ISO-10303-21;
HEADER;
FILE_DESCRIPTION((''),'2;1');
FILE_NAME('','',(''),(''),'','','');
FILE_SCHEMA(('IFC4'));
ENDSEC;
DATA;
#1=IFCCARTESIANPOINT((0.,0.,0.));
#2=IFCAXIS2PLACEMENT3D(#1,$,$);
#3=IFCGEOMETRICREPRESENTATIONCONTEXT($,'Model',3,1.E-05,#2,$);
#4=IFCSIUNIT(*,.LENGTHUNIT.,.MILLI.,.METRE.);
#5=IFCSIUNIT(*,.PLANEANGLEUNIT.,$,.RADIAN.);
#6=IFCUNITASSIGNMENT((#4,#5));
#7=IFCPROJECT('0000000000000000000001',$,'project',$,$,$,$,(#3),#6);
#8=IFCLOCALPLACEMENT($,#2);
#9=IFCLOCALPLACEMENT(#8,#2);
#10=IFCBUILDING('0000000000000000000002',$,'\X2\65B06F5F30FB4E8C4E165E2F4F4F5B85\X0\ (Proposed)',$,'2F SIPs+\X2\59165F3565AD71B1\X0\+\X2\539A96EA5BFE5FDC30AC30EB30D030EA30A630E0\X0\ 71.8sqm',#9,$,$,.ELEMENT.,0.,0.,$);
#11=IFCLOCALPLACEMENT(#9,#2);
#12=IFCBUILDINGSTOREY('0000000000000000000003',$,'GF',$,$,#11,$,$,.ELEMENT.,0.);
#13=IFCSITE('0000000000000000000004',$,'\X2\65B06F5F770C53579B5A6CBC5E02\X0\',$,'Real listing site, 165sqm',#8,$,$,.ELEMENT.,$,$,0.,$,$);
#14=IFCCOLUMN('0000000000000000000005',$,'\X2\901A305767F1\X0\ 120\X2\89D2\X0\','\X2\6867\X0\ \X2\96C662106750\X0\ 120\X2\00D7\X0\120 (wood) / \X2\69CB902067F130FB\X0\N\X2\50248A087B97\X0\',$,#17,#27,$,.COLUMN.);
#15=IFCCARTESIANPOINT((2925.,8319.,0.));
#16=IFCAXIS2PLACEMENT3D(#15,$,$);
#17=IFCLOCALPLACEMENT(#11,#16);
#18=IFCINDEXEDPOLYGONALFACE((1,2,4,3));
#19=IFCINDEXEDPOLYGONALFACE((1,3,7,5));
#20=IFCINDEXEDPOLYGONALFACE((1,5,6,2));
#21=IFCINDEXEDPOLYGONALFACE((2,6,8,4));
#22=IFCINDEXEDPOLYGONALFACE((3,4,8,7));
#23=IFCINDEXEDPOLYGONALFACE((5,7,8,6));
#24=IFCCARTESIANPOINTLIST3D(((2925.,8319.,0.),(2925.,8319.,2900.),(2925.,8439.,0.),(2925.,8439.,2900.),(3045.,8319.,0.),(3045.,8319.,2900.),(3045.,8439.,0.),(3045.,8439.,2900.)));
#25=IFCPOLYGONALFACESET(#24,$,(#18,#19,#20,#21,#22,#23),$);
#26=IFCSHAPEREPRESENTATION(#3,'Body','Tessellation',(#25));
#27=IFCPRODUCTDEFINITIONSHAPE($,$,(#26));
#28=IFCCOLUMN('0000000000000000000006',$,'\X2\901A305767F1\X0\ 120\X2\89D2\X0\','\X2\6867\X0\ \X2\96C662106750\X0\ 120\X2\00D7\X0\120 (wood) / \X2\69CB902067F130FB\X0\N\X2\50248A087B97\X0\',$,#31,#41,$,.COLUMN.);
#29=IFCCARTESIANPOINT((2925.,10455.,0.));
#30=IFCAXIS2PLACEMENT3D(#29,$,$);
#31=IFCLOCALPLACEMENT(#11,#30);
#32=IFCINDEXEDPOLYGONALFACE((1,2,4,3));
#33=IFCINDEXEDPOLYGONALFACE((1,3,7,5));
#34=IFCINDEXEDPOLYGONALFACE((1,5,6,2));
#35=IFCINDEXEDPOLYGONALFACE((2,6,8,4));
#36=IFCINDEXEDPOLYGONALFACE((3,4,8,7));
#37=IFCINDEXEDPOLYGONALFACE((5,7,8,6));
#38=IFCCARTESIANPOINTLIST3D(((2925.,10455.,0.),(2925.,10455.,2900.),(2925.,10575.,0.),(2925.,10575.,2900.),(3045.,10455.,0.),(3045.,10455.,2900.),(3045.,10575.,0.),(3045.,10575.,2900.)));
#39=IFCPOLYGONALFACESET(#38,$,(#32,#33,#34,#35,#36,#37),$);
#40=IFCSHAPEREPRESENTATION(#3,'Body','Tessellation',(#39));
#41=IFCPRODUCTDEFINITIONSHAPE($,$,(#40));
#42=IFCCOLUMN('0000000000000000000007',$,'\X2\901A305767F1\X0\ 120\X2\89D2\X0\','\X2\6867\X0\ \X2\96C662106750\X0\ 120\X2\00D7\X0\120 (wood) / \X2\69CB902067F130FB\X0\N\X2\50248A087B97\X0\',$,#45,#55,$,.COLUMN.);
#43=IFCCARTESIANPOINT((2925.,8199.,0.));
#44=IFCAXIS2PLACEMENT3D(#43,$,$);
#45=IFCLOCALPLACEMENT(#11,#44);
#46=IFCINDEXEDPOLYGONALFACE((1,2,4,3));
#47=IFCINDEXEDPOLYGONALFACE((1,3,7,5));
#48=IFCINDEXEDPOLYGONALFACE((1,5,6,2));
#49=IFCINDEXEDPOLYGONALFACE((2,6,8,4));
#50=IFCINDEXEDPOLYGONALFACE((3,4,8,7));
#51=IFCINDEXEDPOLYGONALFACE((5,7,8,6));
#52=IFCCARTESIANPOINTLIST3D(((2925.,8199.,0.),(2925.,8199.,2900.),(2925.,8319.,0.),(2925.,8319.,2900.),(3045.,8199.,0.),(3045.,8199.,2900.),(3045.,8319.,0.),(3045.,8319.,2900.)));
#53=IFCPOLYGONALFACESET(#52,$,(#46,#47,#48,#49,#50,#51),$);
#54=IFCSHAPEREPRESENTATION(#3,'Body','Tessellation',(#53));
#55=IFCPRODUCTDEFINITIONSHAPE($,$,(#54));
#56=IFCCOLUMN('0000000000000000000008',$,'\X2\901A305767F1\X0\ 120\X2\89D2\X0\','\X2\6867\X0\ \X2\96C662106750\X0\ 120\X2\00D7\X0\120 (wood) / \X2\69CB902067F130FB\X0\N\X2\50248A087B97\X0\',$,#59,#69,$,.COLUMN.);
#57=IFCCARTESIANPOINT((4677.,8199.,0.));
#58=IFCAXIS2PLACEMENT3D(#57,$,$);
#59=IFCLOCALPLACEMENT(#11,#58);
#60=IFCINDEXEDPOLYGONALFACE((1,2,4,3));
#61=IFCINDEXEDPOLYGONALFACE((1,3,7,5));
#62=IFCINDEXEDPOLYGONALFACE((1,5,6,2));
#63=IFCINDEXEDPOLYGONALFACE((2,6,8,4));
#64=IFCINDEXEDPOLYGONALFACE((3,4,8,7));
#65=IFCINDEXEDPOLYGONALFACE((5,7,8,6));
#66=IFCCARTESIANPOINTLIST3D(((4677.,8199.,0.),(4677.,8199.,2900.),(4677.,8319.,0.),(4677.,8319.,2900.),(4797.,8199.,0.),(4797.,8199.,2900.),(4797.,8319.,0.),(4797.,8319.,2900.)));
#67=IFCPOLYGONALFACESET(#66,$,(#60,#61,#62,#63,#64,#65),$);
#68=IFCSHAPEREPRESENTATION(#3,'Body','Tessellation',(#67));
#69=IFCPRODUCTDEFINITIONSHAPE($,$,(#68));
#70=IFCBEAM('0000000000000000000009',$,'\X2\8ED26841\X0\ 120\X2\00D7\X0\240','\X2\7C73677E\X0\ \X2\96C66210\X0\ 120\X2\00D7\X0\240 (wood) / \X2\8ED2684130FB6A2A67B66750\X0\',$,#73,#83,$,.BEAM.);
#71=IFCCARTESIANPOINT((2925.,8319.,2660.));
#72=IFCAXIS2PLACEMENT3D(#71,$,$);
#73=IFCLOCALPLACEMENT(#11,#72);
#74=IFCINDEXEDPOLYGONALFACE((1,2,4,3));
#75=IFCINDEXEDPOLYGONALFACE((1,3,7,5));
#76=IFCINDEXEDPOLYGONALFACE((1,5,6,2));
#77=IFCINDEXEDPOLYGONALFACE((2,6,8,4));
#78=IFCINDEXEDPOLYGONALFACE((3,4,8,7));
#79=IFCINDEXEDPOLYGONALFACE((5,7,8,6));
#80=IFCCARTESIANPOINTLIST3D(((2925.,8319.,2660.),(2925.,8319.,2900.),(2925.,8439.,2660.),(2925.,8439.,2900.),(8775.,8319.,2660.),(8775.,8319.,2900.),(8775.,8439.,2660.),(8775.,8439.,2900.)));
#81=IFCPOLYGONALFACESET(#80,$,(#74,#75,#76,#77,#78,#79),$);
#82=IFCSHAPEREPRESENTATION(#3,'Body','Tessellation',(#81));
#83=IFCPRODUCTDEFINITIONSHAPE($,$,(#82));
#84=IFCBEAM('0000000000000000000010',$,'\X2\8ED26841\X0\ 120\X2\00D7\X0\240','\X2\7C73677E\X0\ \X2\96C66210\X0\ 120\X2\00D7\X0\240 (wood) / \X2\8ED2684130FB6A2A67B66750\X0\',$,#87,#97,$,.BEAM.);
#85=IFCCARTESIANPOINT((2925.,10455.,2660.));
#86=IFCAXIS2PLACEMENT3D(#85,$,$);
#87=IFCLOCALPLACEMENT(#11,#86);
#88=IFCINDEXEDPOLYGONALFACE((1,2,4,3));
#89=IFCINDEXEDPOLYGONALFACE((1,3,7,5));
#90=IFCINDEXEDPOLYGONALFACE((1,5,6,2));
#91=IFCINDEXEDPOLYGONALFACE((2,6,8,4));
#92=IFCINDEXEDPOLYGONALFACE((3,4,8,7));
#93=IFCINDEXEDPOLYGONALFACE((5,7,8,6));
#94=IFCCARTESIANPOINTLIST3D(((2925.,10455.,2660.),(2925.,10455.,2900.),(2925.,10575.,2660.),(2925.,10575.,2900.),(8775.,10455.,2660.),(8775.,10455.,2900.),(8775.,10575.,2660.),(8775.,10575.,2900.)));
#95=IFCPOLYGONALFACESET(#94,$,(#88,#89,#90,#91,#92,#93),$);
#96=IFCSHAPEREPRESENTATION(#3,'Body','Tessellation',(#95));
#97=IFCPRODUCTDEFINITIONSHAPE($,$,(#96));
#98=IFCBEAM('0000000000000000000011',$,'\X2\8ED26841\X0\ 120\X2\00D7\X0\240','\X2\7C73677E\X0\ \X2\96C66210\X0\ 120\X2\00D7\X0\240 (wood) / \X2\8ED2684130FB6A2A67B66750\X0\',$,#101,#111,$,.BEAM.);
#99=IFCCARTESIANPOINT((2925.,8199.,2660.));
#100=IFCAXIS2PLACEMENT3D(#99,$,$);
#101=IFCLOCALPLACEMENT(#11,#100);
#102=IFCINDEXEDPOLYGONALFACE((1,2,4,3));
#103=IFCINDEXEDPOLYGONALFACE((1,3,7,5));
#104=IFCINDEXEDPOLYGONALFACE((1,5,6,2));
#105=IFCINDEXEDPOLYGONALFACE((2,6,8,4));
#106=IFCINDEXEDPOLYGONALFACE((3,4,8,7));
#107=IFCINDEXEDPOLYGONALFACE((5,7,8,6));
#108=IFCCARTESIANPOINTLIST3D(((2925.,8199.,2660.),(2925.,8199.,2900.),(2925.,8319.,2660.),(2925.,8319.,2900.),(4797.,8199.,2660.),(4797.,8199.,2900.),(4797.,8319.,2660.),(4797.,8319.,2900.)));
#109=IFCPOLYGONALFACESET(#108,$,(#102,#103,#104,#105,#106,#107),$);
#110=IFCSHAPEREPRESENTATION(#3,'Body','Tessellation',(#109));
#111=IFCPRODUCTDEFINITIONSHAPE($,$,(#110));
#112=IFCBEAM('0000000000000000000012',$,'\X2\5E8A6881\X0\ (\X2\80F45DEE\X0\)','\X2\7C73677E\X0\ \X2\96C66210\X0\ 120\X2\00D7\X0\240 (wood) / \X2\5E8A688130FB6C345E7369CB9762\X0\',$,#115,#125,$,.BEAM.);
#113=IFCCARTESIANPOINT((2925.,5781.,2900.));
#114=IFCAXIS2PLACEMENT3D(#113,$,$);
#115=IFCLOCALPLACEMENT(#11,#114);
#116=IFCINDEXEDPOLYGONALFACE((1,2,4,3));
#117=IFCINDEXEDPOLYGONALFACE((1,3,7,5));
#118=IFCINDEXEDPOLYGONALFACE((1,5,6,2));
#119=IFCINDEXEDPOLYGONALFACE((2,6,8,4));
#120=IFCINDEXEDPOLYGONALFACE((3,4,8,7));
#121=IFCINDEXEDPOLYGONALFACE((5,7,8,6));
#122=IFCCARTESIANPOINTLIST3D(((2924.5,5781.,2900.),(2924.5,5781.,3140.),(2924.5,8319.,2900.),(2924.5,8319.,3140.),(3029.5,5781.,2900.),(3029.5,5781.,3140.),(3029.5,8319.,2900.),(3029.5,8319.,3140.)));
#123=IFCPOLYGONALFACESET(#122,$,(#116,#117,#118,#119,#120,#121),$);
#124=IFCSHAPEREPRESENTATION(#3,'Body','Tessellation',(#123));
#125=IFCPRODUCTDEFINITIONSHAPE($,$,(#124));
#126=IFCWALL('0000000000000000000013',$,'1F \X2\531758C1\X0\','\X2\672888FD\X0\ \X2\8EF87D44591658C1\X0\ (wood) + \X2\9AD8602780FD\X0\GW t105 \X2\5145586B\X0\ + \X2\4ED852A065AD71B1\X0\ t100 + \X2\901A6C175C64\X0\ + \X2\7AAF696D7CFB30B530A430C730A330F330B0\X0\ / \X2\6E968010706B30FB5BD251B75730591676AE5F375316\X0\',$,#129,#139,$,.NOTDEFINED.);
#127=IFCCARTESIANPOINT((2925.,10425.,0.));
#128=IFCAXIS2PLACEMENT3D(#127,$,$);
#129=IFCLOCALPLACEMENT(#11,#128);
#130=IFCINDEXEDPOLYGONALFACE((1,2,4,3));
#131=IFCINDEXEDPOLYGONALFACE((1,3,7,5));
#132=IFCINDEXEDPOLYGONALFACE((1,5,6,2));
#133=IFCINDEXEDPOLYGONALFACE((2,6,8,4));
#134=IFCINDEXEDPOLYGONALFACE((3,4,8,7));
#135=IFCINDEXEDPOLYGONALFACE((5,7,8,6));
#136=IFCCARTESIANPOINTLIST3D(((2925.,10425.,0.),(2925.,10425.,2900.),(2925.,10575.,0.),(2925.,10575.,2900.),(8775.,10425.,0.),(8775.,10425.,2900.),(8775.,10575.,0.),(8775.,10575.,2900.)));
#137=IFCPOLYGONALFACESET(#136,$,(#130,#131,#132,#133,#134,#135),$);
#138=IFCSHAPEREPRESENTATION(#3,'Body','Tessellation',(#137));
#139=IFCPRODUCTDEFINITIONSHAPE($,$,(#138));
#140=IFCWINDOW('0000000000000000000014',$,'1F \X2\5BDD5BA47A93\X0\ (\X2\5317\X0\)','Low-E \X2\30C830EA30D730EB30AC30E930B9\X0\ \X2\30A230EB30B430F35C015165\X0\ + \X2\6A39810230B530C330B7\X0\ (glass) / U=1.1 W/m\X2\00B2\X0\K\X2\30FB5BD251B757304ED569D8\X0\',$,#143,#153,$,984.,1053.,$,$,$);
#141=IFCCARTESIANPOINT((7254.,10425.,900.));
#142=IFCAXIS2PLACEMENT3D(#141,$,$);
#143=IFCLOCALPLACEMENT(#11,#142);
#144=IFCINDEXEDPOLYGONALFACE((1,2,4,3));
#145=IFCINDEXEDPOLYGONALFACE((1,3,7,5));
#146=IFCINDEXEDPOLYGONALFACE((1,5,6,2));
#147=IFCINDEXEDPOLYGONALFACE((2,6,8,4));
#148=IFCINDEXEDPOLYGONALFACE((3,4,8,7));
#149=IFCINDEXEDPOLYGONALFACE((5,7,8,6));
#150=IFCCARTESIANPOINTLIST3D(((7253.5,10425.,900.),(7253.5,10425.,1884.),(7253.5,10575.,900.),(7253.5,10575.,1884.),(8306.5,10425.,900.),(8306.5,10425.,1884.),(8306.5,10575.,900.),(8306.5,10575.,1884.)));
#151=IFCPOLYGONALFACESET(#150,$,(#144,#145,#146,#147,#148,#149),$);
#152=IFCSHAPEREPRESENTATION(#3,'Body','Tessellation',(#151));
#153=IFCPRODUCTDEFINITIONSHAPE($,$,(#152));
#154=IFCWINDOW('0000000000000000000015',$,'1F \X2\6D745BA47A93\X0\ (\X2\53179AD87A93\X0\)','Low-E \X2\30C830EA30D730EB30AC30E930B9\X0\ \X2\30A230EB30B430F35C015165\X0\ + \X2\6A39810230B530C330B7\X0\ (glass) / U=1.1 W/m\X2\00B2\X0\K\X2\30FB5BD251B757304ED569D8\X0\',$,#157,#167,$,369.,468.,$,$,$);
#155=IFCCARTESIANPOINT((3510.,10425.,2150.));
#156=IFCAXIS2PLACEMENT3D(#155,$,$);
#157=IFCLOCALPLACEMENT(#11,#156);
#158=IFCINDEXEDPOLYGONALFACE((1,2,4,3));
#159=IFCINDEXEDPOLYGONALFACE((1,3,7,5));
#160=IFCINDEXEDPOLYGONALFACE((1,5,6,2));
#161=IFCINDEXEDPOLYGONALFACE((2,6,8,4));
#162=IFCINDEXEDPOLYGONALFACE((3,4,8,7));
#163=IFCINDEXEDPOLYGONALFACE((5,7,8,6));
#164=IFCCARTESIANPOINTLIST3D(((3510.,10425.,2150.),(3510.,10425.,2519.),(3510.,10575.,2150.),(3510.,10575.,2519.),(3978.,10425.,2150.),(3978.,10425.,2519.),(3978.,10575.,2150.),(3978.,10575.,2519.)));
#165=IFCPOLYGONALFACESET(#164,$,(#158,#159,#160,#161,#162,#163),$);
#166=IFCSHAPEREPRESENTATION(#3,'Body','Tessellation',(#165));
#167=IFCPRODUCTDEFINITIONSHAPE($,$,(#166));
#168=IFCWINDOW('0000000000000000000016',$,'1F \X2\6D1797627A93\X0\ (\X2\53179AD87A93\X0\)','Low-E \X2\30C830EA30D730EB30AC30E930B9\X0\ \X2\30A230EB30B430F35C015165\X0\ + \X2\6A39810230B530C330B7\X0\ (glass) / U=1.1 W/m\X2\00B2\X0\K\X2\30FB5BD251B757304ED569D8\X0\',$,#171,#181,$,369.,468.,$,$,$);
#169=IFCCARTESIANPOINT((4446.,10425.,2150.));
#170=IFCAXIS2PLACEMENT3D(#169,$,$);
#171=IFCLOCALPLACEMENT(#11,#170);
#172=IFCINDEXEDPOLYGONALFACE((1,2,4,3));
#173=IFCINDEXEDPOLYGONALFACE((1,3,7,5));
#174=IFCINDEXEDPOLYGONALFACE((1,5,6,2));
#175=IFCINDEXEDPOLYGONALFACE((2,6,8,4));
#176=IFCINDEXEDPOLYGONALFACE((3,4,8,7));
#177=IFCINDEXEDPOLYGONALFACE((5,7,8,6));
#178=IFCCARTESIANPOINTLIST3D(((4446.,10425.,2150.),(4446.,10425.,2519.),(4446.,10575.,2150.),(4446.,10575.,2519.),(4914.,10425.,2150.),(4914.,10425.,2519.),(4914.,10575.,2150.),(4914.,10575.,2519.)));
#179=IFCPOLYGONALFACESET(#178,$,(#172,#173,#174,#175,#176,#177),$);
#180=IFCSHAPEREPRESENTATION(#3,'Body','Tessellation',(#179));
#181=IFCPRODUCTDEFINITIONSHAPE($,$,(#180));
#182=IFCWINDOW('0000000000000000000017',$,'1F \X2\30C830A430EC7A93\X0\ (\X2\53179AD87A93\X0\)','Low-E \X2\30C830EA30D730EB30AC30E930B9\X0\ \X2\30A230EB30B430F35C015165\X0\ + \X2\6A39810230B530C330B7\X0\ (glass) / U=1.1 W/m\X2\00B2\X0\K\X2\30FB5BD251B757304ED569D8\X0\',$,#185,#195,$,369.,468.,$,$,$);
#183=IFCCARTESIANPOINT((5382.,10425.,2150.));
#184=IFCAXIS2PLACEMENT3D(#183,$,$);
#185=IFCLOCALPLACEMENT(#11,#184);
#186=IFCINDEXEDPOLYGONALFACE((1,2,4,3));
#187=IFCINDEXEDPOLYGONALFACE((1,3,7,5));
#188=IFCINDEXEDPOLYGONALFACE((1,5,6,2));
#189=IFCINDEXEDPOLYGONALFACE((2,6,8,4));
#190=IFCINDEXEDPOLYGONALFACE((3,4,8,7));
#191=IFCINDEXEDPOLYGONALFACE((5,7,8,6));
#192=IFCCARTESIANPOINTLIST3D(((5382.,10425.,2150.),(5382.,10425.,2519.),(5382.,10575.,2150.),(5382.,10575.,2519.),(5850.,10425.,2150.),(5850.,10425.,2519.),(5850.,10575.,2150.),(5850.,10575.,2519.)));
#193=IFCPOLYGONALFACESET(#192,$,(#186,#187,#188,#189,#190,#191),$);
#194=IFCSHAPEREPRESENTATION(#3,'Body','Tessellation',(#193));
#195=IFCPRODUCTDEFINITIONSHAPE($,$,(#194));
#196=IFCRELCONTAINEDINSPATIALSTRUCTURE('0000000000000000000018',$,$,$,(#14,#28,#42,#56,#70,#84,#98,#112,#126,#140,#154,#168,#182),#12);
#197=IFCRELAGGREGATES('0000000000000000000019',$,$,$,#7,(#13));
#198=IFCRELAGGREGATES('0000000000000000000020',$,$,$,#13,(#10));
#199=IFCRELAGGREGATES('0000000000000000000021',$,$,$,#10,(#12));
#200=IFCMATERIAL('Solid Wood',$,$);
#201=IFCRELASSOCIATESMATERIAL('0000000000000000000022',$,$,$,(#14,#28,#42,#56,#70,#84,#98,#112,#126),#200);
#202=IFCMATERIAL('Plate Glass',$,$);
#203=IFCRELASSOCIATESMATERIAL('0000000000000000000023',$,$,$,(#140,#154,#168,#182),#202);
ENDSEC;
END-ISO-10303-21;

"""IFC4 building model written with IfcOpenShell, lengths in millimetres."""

from ifc_helpers import new_model, si_unit, frame, frame_2d, origin, place, context, project, spatial, rectangle, extrude, material, element, fill, save


model = new_model("IFC4")

# Units and contexts
model_context = context("Model", 3, precision=1e-05, world=origin())
ifc_project = project(units=[si_unit("LENGTHUNIT", "METRE", prefix="MILLI"), si_unit("PLANEANGLEUNIT", "RADIAN")], contexts=[model_context])

# Site, building, storey
site_placement = place(None, origin())
site = spatial("IfcSite", under=ifc_project, at=site_placement, Name="新潟県南魚沼市", ObjectType="Real listing site, 165sqm", CompositionType="ELEMENT", RefElevation=0.0)
building_placement = place(site_placement, origin())
building = spatial("IfcBuilding", under=site, at=building_placement, Name="新潟・二世帯住宅 (Proposed)", ObjectType="2F SIPs+外張断熱+厚雪対応ガルバリウム 71.8sqm", CompositionType="ELEMENT", ElevationOfRefHeight=0.0, ElevationOfTerrain=0.0)
storey_placement = place(building_placement, origin())
storey = spatial("IfcBuildingStorey", under=building, at=storey_placement, Name="GF", CompositionType="ELEMENT", Elevation=0.0)

# Columns
ifc_material_1 = material(Name="Solid Wood")
column_1_placement = place(storey_placement, frame((2925.0, 8319.0, 0.0)))
element("IfcColumn", 1, at=column_1_placement, inside=storey, material=ifc_material_1, Name="通し柱 120角", Description="桧 集成材 120×120 (wood) / 構造柱・N値計算", PredefinedType="COLUMN", context=model_context, shape_type="SweptSolid", body=[
    extrude(rectangle(XDim=120.0, YDim=120.0, at=frame_2d((60.0, 60.0))), frame((2925.0, 8319.0, 0.0)), (0.0, 0.0, 1.0), 2900.0),
])
column_2_placement = place(storey_placement, frame((2925.0, 10455.0, 0.0)))
element("IfcColumn", 2, at=column_2_placement, inside=storey, material=ifc_material_1, Name="通し柱 120角", Description="桧 集成材 120×120 (wood) / 構造柱・N値計算", PredefinedType="COLUMN", context=model_context, shape_type="SweptSolid", body=[
    extrude(rectangle(XDim=120.0, YDim=120.0, at=frame_2d((60.0, 60.0))), frame((2925.0, 10455.0, 0.0)), (0.0, 0.0, 1.0), 2900.0),
])
column_3_placement = place(storey_placement, frame((2925.0, 8199.0, 0.0)))
element("IfcColumn", 3, at=column_3_placement, inside=storey, material=ifc_material_1, Name="通し柱 120角", Description="桧 集成材 120×120 (wood) / 構造柱・N値計算", PredefinedType="COLUMN", context=model_context, shape_type="SweptSolid", body=[
    extrude(rectangle(XDim=120.0, YDim=120.0, at=frame_2d((60.0, 60.0))), frame((2925.0, 8199.0, 0.0)), (0.0, 0.0, 1.0), 2900.0),
])
column_4_placement = place(storey_placement, frame((4677.0, 8199.0, 0.0)))
element("IfcColumn", 4, at=column_4_placement, inside=storey, material=ifc_material_1, Name="通し柱 120角", Description="桧 集成材 120×120 (wood) / 構造柱・N値計算", PredefinedType="COLUMN", context=model_context, shape_type="SweptSolid", body=[
    extrude(rectangle(XDim=120.0, YDim=120.0, at=frame_2d((60.0, 60.0))), frame((4677.0, 8199.0, 0.0)), (0.0, 0.0, 1.0), 2900.0),
])

# Beams
beam_1_placement = place(storey_placement, frame((2925.0, 8319.0, 2660.0)))
element("IfcBeam", 5, at=beam_1_placement, inside=storey, material=ifc_material_1, Name="軒桁 120×240", Description="米松 集成 120×240 (wood) / 軒桁・横架材", PredefinedType="BEAM", context=model_context, shape_type="SweptSolid", body=[
    extrude(rectangle(XDim=5850.0, YDim=120.0, at=frame_2d((2925.0, 60.0))), frame((2925.0, 8319.0, 2660.0)), (0.0, 0.0, 1.0), 240.0),
])
beam_2_placement = place(storey_placement, frame((2925.0, 10455.0, 2660.0)))
element("IfcBeam", 6, at=beam_2_placement, inside=storey, material=ifc_material_1, Name="軒桁 120×240", Description="米松 集成 120×240 (wood) / 軒桁・横架材", PredefinedType="BEAM", context=model_context, shape_type="SweptSolid", body=[
    extrude(rectangle(XDim=5850.0, YDim=120.0, at=frame_2d((2925.0, 60.0))), frame((2925.0, 10455.0, 2660.0)), (0.0, 0.0, 1.0), 240.0),
])
beam_3_placement = place(storey_placement, frame((2925.0, 8199.0, 2660.0)))
element("IfcBeam", 7, at=beam_3_placement, inside=storey, material=ifc_material_1, Name="軒桁 120×240", Description="米松 集成 120×240 (wood) / 軒桁・横架材", PredefinedType="BEAM", context=model_context, shape_type="SweptSolid", body=[
    extrude(rectangle(XDim=1872.0, YDim=120.0, at=frame_2d((936.0, 60.0))), frame((2925.0, 8199.0, 2660.0)), (0.0, 0.0, 1.0), 240.0),
])
beam_4_placement = place(storey_placement, frame((2925.0, 5781.0, 2900.0)))
element("IfcBeam", 8, at=beam_4_placement, inside=storey, material=ifc_material_1, Name="床梁 (胴差)", Description="米松 集成 120×240 (wood) / 床梁・水平構面", PredefinedType="BEAM", context=model_context, shape_type="SweptSolid", body=[
    extrude(rectangle(XDim=105.0, YDim=2538.0, at=frame_2d((52.0, 1269.0))), frame((2925.0, 5781.0, 2900.0)), (0.0, 0.0, 1.0), 240.0),
])

# Wall, openings, windows
wall_1_placement = place(storey_placement, frame((2925.0, 10425.0, 0.0)))
wall_1 = element("IfcWall", 9, at=wall_1_placement, inside=storey, material=ifc_material_1, Name="1F 北壁", Description="木製 軸組外壁 (wood) + 高性能GW t105 充填 + 付加断熱 t100 + 通気層 + 窯業系サイディング / 準耐火・寒冷地外皮強化", PredefinedType="NOTDEFINED", context=model_context, shape_type="SweptSolid", body=[
    extrude(rectangle(XDim=5850.0, YDim=150.0, at=frame_2d((2925.0, 75.0))), frame((2925.0, 10425.0, 0.0)), (0.0, 0.0, 1.0), 2900.0),
])
opening_1_placement = place(storey_placement, frame((7254.0, 10425.0, 900.0)))
opening_1 = element("IfcOpeningElement", 10, at=opening_1_placement, cuts=wall_1, PredefinedType="NOTDEFINED", context=model_context, shape_type="SweptSolid", body=[
    extrude(rectangle(XDim=1053.0, YDim=150.0, at=frame_2d((526.0, 75.0))), frame((7254.0, 10425.0, 900.0)), (0.0, 0.0, 1.0), 984.0),
])
opening_2_placement = place(storey_placement, frame((3510.0, 10425.0, 2150.0)))
opening_2 = element("IfcOpeningElement", 11, at=opening_2_placement, cuts=wall_1, PredefinedType="NOTDEFINED", context=model_context, shape_type="SweptSolid", body=[
    extrude(rectangle(XDim=468.0, YDim=150.0, at=frame_2d((234.0, 75.0))), frame((3510.0, 10425.0, 2150.0)), (0.0, 0.0, 1.0), 369.0),
])
opening_3_placement = place(storey_placement, frame((4446.0, 10425.0, 2150.0)))
opening_3 = element("IfcOpeningElement", 12, at=opening_3_placement, cuts=wall_1, PredefinedType="NOTDEFINED", context=model_context, shape_type="SweptSolid", body=[
    extrude(rectangle(XDim=468.0, YDim=150.0, at=frame_2d((234.0, 75.0))), frame((4446.0, 10425.0, 2150.0)), (0.0, 0.0, 1.0), 369.0),
])
opening_4_placement = place(storey_placement, frame((5382.0, 10425.0, 2150.0)))
opening_4 = element("IfcOpeningElement", 13, at=opening_4_placement, cuts=wall_1, PredefinedType="NOTDEFINED", context=model_context, shape_type="SweptSolid", body=[
    extrude(rectangle(XDim=468.0, YDim=150.0, at=frame_2d((234.0, 75.0))), frame((5382.0, 10425.0, 2150.0)), (0.0, 0.0, 1.0), 369.0),
])
ifc_material_2 = material(Name="Plate Glass")
window_1_placement = place(storey_placement, frame((7254.0, 10425.0, 900.0)))
window_1 = element("IfcWindow", 14, at=window_1_placement, inside=storey, material=ifc_material_2, Name="1F 寝室窓 (北)", Description="Low-E トリプルガラス アルゴン封入 + 樹脂サッシ (glass) / U=1.1 W/m²K・寒冷地仕様", OverallHeight=984.0, OverallWidth=1053.0, context=model_context, shape_type="SweptSolid", body=[
    extrude(rectangle(XDim=1053.0, YDim=150.0, at=frame_2d((526.0, 75.0))), frame((7254.0, 10425.0, 900.0)), (0.0, 0.0, 1.0), 984.0),
])
fill(opening_1, window_1)
window_2_placement = place(storey_placement, frame((3510.0, 10425.0, 2150.0)))
window_2 = element("IfcWindow", 15, at=window_2_placement, inside=storey, material=ifc_material_2, Name="1F 浴室窓 (北高窓)", Description="Low-E トリプルガラス アルゴン封入 + 樹脂サッシ (glass) / U=1.1 W/m²K・寒冷地仕様", OverallHeight=369.0, OverallWidth=468.0, context=model_context, shape_type="SweptSolid", body=[
    extrude(rectangle(XDim=468.0, YDim=150.0, at=frame_2d((234.0, 75.0))), frame((3510.0, 10425.0, 2150.0)), (0.0, 0.0, 1.0), 369.0),
])
fill(opening_2, window_2)
window_3_placement = place(storey_placement, frame((4446.0, 10425.0, 2150.0)))
window_3 = element("IfcWindow", 16, at=window_3_placement, inside=storey, material=ifc_material_2, Name="1F 洗面窓 (北高窓)", Description="Low-E トリプルガラス アルゴン封入 + 樹脂サッシ (glass) / U=1.1 W/m²K・寒冷地仕様", OverallHeight=369.0, OverallWidth=468.0, context=model_context, shape_type="SweptSolid", body=[
    extrude(rectangle(XDim=468.0, YDim=150.0, at=frame_2d((234.0, 75.0))), frame((4446.0, 10425.0, 2150.0)), (0.0, 0.0, 1.0), 369.0),
])
fill(opening_3, window_3)
window_4_placement = place(storey_placement, frame((5382.0, 10425.0, 2150.0)))
window_4 = element("IfcWindow", 17, at=window_4_placement, inside=storey, material=ifc_material_2, Name="1F トイレ窓 (北高窓)", Description="Low-E トリプルガラス アルゴン封入 + 樹脂サッシ (glass) / U=1.1 W/m²K・寒冷地仕様", OverallHeight=369.0, OverallWidth=468.0, context=model_context, shape_type="SweptSolid", body=[
    extrude(rectangle(XDim=468.0, YDim=150.0, at=frame_2d((234.0, 75.0))), frame((5382.0, 10425.0, 2150.0)), (0.0, 0.0, 1.0), 369.0),
])
fill(opening_4, window_4)

save(model, "model.ifc")
